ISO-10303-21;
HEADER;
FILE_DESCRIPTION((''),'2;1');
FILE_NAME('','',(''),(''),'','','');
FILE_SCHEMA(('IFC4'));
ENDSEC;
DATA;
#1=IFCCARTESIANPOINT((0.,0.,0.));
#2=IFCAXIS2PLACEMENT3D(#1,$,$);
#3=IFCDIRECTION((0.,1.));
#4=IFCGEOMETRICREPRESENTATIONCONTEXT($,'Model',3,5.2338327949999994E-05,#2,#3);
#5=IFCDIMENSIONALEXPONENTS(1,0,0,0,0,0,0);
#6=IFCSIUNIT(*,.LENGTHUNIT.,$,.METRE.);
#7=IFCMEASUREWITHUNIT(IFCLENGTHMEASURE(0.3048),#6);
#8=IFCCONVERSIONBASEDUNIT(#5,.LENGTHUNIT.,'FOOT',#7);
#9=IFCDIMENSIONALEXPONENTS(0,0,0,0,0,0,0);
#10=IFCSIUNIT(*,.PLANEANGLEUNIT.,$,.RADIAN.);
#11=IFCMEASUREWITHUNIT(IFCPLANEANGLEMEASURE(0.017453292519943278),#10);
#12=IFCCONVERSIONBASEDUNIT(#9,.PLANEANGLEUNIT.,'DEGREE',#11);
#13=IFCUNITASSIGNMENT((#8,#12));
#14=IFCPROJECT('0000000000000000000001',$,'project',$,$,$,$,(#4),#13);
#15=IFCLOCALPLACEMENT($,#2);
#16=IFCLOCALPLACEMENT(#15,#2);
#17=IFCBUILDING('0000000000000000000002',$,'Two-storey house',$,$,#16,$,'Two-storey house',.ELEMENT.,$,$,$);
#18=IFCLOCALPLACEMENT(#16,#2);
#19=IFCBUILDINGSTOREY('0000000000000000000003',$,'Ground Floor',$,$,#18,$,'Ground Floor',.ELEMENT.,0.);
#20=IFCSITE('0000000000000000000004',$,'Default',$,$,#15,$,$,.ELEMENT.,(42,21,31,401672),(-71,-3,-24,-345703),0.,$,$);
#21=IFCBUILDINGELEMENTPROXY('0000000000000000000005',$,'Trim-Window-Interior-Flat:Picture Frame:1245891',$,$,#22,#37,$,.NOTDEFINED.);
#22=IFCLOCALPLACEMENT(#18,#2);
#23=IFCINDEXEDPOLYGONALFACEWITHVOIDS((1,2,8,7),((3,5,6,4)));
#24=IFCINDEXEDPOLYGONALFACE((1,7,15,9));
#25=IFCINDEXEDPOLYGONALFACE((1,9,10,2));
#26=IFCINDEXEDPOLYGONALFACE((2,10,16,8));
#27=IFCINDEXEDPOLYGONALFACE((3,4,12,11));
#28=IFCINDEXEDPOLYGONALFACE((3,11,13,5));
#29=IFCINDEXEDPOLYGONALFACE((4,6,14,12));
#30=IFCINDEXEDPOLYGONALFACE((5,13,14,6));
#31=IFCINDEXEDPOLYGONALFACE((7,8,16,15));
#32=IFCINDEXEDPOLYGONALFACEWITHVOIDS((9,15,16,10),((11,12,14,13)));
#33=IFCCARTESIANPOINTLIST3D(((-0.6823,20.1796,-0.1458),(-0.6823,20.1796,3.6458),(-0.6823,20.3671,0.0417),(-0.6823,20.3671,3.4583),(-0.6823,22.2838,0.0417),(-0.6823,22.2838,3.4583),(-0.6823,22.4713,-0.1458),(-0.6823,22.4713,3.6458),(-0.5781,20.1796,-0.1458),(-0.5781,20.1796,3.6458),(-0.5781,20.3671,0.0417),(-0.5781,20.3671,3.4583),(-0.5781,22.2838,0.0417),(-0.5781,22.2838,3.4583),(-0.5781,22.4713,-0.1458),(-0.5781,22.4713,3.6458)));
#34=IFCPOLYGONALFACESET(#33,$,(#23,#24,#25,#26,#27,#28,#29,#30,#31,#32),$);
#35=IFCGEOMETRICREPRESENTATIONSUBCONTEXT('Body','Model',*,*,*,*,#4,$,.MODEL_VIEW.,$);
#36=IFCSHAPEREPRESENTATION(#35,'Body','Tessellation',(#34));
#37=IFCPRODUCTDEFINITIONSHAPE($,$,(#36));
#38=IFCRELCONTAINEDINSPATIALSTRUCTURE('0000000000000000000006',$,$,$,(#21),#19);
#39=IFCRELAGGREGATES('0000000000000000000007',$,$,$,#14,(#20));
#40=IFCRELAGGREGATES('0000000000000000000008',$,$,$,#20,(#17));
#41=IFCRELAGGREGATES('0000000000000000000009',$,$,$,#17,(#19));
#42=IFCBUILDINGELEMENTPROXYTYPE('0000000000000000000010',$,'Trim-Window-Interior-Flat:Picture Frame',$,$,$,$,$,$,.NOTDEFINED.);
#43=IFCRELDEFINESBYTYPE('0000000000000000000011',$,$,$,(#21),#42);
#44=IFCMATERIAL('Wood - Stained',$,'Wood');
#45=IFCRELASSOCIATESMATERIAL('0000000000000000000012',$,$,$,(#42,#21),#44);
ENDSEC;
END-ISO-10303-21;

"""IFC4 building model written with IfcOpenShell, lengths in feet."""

from ifc_helpers import new_model, entity, si_unit, converted_unit, direction, frame, origin, place, context, subcontext, project, spatial, indexed_curve, outline, extrude, source, transform, mapped, material, type_object, type_shapes, element, save


model = new_model("IFC4")

# Units and contexts
model_context = context("Model", 3, precision=5.2338327949999994e-05, world=origin(), true_north=direction((0.0, 1.0)))
body_context = subcontext(model_context, "Body", "Model", "MODEL_VIEW")
ifc_project = project(units=[converted_unit("LENGTHUNIT", "FOOT", entity("IfcLengthMeasure", 0.3048), si_unit("LENGTHUNIT", "METRE"), dimensions=[1, 0, 0, 0, 0, 0, 0]), converted_unit("PLANEANGLEUNIT", "DEGREE", entity("IfcPlaneAngleMeasure", 0.017453292519943278), si_unit("PLANEANGLEUNIT", "RADIAN"), dimensions=[0, 0, 0, 0, 0, 0, 0])], contexts=[model_context])

# Site, building, storey
site_placement = place(None, origin())
building_placement = place(site_placement, origin())
storey_placement = place(building_placement, origin())
site = spatial("IfcSite", under=ifc_project, at=site_placement, Name="Default", CompositionType="ELEMENT", RefLatitude=(42, 21, 31, 401672), RefLongitude=(-71, -3, -24, -345703), RefElevation=0.0)
building = spatial("IfcBuilding", under=site, at=building_placement, Name="Two-storey house", LongName="Two-storey house", CompositionType="ELEMENT")
storey = spatial("IfcBuildingStorey", under=building, at=storey_placement, Name="Ground Floor", LongName="Ground Floor", CompositionType="ELEMENT", Elevation=0.0)

# Shared definitions
ifc_material_1 = material(Name="Wood - Stained", Category="Wood")

# Building element proxy
building_element_proxy_type_1 = type_object("IfcBuildingElementProxyType", Name="Trim-Window-Interior-Flat:Picture Frame", PredefinedType="NOTDEFINED", material=ifc_material_1)
shared_shape_1 = source(origin(), body_context, "Body", "SweptSolid", [
    extrude(outline(indexed_curve([(-1.1458, -1.8958), (1.1458, -1.8958), (1.1458, 1.8958), (-1.1458, 1.8958), (-1.1458, -1.8958)], self_intersect=False), holes=[indexed_curve([(-0.9583, -1.7083), (-0.9583, 1.7083), (0.9583, 1.7083), (0.9583, -1.7083), (-0.9583, -1.7083)], self_intersect=False)]), frame((0.0, -1.75, 0.0), z_axis=(0.0, 0.0, 1.0), x_axis=(-1.0, 0.0, 0.0)), (0.0, 0.0, 1.0), 0.1042),
])
type_shapes(building_element_proxy_type_1, [shared_shape_1])
for number, where, z_axis, x_axis, name in (
    (1, (-0.5781, 21.3255, 3.5), (-1.0, 0.0, 0.0), (0.0, -1.0, 0.0), "Trim-Window-Interior-Flat:Picture Frame:1245891"),
):
    element("IfcBuildingElementProxy", number, at=place(storey_placement, frame(where, z_axis=z_axis, x_axis=x_axis)), inside=storey, type_object=building_element_proxy_type_1, material=ifc_material_1, Name=name, PredefinedType="NOTDEFINED", context=body_context, shape_type="MappedRepresentation", body=[
        mapped(shared_shape_1, transform((0.0, 0.0, 0.0), scale=1.0)),
    ])

save(model, "model.ifc")
